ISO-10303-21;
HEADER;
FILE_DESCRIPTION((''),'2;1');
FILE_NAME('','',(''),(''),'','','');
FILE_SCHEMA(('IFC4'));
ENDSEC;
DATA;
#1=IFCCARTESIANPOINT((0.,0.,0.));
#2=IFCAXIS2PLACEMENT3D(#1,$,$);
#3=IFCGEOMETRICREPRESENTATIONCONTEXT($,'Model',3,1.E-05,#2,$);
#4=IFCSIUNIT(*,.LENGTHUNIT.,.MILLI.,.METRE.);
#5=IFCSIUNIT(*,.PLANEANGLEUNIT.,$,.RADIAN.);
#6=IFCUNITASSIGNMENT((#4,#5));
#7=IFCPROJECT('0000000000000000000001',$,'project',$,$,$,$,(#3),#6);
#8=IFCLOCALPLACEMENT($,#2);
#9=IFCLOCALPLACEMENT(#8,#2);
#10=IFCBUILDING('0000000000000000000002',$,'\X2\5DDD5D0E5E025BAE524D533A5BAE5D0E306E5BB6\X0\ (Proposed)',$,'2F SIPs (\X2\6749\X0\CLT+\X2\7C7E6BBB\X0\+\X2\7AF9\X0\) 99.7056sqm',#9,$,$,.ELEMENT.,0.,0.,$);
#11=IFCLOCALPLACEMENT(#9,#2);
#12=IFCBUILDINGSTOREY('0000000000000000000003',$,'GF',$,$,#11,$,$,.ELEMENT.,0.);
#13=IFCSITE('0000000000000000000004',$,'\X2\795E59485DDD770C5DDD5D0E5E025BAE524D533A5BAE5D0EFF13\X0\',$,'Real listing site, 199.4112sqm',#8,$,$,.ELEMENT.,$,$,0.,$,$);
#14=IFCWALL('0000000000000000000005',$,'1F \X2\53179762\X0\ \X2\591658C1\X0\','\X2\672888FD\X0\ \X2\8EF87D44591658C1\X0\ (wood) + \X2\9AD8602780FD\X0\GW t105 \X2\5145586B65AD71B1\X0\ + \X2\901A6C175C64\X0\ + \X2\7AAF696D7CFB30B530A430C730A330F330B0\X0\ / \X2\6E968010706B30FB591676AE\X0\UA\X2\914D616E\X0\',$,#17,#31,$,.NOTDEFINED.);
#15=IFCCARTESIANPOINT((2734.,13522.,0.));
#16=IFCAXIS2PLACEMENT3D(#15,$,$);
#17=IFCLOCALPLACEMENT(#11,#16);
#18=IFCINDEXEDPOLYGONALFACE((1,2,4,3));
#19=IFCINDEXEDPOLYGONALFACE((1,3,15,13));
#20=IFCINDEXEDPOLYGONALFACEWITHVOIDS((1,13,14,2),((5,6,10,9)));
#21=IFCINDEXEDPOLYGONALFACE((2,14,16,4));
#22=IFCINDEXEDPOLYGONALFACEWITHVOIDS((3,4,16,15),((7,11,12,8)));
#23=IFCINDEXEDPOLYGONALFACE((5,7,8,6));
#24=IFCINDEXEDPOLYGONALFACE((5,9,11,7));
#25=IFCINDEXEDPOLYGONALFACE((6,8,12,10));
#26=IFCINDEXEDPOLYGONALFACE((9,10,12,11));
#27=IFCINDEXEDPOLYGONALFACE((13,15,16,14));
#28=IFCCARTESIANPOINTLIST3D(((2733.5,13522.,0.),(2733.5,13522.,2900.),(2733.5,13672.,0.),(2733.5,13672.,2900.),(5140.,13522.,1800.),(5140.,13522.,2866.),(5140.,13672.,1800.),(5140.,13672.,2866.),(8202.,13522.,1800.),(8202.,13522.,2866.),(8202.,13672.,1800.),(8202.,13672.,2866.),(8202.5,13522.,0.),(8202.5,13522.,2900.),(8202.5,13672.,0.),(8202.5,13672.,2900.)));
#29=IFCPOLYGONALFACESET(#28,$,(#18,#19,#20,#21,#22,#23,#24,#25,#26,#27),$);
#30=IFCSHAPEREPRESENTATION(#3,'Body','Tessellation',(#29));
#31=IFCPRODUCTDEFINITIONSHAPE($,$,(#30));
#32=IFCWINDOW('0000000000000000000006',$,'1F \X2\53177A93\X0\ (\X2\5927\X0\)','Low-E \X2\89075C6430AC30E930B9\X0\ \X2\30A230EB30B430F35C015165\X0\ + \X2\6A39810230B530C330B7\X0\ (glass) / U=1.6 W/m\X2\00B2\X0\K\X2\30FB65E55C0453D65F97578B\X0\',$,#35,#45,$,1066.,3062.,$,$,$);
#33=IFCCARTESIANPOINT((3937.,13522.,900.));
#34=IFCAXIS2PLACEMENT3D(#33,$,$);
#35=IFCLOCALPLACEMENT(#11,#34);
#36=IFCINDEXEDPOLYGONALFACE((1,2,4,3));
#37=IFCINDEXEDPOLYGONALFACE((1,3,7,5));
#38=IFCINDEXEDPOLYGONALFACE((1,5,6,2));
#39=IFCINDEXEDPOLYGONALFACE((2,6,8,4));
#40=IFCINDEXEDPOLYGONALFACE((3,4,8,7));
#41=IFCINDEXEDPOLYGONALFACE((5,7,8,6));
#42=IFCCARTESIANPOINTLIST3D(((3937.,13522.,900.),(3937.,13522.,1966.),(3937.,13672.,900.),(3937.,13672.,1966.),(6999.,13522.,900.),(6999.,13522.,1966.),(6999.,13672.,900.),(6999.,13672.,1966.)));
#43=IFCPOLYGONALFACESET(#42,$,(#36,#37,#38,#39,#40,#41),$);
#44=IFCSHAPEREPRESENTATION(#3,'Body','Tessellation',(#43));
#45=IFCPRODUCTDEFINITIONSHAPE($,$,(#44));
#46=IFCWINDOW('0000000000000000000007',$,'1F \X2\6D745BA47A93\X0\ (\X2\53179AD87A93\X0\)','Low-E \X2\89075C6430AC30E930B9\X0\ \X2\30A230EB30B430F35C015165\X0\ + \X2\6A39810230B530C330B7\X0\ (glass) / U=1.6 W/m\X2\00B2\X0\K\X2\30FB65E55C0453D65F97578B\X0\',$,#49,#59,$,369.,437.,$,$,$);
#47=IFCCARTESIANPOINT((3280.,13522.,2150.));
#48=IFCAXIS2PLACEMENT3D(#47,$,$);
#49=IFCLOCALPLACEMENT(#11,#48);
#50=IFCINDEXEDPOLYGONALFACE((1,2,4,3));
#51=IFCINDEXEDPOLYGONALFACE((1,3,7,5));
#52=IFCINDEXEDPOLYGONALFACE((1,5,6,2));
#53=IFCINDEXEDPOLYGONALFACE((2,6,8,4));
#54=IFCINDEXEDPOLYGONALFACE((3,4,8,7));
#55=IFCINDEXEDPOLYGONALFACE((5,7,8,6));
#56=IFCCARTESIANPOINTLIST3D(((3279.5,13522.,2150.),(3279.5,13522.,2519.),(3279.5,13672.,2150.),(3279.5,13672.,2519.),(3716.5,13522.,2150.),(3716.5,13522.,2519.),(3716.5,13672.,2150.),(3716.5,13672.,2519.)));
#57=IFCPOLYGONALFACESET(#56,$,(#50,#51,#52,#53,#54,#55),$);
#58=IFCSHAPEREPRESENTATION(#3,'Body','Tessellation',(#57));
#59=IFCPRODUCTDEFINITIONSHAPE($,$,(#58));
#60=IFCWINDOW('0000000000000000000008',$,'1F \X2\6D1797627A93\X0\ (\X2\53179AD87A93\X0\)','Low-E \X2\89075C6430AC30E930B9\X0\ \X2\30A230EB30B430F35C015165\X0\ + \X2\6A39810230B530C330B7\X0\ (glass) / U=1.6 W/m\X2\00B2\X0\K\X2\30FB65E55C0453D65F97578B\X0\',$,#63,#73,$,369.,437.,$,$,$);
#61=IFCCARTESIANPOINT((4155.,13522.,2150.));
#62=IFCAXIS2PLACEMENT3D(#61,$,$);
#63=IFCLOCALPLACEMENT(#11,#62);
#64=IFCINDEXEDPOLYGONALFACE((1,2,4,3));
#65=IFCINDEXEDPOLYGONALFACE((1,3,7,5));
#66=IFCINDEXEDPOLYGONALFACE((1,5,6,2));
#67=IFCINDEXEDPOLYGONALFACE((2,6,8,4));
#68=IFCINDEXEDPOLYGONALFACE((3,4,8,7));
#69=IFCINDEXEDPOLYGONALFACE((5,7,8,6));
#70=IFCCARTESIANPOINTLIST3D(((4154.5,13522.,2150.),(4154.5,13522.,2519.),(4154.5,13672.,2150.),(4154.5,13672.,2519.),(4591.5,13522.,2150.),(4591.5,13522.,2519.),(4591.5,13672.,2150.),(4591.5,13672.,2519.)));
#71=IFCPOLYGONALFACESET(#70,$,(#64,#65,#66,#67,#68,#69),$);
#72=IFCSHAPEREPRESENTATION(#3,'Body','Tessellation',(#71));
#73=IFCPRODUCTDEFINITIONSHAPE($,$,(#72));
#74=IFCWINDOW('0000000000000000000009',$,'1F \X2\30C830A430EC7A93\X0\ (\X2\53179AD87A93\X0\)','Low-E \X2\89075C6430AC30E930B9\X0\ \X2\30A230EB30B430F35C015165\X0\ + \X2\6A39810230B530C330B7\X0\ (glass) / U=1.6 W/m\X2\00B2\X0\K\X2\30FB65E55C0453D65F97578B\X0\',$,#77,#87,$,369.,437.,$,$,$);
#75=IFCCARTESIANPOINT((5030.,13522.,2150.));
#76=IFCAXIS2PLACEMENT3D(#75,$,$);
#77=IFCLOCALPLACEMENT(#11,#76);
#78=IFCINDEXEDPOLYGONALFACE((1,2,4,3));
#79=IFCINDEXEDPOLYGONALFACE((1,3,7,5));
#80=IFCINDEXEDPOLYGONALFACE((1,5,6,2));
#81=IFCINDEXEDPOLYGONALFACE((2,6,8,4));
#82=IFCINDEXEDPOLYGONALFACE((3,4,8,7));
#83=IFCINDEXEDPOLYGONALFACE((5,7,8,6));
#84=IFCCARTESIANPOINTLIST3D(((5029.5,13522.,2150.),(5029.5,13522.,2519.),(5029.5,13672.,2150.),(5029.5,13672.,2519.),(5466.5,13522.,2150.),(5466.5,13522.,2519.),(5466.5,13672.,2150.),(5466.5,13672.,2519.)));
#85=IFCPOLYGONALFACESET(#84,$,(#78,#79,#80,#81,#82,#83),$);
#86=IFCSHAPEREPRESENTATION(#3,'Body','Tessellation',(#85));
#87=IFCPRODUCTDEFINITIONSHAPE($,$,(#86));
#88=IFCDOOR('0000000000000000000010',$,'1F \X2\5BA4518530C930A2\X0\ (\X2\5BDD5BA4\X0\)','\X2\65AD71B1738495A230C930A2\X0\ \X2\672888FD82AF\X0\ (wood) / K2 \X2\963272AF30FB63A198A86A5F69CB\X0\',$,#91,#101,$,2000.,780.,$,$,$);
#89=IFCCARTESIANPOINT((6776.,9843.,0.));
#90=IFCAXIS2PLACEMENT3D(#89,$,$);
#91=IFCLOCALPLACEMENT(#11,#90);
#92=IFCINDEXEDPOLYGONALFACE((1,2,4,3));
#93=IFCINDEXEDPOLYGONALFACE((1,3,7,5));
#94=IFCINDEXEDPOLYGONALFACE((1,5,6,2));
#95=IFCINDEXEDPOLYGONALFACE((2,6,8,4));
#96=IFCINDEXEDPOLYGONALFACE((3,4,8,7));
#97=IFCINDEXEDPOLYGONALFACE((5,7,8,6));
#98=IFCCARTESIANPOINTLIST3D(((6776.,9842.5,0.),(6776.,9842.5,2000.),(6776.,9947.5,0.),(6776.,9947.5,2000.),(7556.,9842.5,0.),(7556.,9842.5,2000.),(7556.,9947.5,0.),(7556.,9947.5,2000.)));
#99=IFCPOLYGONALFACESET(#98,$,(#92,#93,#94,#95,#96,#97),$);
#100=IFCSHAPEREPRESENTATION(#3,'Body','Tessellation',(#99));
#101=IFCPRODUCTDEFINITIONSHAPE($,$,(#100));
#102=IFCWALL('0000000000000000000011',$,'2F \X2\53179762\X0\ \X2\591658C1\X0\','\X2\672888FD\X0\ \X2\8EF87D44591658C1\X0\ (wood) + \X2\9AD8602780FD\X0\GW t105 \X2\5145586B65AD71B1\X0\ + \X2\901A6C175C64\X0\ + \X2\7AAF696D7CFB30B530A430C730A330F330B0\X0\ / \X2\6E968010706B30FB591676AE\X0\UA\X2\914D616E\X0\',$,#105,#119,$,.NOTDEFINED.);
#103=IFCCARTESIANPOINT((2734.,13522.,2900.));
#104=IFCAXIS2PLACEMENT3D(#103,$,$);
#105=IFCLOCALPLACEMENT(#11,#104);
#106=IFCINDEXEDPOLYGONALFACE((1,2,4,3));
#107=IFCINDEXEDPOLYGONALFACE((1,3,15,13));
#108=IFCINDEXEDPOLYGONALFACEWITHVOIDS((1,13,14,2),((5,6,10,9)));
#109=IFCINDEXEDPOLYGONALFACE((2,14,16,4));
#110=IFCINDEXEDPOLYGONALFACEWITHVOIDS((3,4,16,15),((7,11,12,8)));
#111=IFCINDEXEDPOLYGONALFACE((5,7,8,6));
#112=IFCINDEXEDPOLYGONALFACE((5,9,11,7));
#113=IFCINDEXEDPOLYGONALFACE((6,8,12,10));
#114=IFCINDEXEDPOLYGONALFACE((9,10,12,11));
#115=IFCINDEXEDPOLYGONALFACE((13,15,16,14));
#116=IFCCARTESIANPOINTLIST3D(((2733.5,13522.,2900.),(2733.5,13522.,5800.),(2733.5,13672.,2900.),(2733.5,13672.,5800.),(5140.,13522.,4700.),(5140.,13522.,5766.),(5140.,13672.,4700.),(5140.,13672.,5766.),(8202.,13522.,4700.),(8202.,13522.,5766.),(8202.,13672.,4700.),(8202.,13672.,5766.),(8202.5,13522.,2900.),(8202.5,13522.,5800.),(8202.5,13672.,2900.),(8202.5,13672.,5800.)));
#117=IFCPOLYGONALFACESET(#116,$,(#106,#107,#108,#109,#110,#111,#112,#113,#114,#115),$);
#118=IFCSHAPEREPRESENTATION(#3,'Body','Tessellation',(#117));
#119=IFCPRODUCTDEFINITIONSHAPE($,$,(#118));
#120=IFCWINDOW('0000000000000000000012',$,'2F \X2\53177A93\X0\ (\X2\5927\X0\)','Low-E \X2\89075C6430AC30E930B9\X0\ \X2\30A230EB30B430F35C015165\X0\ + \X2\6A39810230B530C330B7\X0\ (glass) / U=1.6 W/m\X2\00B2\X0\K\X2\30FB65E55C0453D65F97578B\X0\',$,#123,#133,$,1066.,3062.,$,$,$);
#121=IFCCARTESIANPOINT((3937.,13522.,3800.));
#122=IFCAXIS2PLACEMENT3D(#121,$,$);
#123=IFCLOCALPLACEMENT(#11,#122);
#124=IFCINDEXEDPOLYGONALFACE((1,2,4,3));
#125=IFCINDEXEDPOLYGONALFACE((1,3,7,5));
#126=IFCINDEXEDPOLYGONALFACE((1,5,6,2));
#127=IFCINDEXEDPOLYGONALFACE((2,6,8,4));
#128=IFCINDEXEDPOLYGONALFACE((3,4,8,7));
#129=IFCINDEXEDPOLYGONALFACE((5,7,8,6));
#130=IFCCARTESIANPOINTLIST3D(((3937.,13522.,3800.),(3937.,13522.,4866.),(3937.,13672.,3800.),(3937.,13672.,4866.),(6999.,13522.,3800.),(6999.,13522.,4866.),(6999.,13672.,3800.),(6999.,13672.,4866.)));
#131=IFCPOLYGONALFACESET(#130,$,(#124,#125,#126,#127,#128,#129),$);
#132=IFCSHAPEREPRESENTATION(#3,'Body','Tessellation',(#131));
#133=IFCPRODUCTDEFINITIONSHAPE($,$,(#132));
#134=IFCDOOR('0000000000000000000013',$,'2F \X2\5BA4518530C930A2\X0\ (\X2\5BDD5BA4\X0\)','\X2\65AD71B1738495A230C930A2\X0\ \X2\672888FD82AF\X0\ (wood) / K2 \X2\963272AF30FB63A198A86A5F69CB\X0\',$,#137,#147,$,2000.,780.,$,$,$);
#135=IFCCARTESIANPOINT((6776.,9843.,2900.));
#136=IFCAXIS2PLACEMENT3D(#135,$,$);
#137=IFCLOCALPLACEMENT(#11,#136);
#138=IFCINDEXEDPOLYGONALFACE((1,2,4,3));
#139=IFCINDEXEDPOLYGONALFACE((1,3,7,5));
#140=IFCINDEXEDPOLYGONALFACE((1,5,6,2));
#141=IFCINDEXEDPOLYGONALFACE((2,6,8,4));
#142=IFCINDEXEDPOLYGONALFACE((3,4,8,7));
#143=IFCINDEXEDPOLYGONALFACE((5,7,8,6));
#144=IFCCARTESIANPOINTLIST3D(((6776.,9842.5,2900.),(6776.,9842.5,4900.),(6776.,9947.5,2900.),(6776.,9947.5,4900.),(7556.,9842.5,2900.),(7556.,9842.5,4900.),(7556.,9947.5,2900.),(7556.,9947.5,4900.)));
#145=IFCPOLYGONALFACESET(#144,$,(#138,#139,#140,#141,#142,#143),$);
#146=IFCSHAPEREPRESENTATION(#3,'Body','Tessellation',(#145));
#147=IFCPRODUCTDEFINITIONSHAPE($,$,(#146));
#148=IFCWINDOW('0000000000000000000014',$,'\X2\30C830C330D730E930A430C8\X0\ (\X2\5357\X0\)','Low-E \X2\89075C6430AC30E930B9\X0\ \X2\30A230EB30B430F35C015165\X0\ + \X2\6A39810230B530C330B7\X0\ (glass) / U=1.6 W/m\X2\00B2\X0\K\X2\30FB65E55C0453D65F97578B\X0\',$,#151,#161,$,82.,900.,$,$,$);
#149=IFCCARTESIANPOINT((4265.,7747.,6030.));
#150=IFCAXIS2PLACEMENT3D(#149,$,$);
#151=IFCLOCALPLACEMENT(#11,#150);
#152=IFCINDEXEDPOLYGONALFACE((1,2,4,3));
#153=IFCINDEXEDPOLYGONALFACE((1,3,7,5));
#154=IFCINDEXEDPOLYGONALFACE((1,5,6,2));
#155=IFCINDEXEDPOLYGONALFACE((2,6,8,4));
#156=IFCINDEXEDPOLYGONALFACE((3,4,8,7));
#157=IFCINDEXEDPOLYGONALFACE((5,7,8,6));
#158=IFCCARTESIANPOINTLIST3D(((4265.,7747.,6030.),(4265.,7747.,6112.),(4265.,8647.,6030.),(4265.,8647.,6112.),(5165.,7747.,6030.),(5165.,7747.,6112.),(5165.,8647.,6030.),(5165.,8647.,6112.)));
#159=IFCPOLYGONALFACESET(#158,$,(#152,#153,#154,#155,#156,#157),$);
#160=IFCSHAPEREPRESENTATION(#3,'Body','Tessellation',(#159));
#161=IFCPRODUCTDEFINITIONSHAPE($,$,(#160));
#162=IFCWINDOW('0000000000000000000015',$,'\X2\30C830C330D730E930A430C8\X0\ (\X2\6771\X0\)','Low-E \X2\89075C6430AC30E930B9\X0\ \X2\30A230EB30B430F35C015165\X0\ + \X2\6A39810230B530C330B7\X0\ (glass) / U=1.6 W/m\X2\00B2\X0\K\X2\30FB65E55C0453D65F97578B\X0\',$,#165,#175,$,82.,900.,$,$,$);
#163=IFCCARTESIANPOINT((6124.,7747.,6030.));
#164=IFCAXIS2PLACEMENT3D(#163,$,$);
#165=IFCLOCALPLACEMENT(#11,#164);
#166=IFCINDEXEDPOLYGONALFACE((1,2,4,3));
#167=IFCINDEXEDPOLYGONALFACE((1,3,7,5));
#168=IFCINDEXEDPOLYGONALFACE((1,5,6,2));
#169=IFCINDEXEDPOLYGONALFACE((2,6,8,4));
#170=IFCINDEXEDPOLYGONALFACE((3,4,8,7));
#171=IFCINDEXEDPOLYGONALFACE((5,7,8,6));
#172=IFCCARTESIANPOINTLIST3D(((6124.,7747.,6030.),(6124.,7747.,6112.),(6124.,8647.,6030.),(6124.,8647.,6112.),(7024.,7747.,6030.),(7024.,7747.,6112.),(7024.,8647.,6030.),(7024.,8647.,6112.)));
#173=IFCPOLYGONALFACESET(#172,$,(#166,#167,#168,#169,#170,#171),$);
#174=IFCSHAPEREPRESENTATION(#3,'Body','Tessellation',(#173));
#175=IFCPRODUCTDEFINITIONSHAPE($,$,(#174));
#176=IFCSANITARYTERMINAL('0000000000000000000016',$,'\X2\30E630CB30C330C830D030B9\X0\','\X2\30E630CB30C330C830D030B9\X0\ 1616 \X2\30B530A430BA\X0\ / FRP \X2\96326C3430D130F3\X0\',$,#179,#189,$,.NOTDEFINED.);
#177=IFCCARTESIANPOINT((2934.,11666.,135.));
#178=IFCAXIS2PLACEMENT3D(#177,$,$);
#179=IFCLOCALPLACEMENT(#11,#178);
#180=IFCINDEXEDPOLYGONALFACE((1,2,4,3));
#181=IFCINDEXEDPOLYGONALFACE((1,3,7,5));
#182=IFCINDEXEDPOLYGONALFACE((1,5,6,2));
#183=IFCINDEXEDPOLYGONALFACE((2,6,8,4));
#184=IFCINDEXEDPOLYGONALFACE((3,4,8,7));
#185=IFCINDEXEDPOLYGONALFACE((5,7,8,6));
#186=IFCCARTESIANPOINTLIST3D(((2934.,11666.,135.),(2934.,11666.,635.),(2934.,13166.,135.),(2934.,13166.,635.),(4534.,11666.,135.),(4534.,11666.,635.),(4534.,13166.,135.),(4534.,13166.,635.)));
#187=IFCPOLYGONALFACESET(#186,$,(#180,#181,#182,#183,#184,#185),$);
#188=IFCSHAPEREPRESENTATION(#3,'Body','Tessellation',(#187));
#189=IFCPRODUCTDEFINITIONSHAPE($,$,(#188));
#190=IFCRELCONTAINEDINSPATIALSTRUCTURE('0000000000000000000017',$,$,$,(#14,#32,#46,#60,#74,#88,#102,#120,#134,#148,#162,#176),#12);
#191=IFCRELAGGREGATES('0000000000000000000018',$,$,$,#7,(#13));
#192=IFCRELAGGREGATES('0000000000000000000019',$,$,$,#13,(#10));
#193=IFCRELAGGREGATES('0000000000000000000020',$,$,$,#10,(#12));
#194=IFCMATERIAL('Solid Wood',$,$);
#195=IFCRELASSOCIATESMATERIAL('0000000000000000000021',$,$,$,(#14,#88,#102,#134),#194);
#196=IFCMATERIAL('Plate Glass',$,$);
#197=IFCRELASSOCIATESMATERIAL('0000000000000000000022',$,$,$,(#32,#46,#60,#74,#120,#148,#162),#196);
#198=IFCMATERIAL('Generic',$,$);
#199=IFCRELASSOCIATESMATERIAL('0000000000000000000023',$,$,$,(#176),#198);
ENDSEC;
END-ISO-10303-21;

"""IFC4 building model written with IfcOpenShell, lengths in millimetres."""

from ifc_helpers import new_model, si_unit, frame, frame_2d, origin, place, context, project, spatial, rectangle, extrude, material, element, fill, save


model = new_model("IFC4")

# Units and contexts
model_context = context("Model", 3, precision=1e-05, world=origin())
ifc_project = project(units=[si_unit("LENGTHUNIT", "METRE", prefix="MILLI"), si_unit("PLANEANGLEUNIT", "RADIAN")], contexts=[model_context])

# Site, building, storey
site_placement = place(None, origin())
site = spatial("IfcSite", under=ifc_project, at=site_placement, Name="神奈川県川崎市宮前区宮崎３", ObjectType="Real listing site, 199.4112sqm", CompositionType="ELEMENT", RefElevation=0.0)
building_placement = place(site_placement, origin())
building = spatial("IfcBuilding", under=site, at=building_placement, Name="川崎市宮前区宮崎の家 (Proposed)", ObjectType="2F SIPs (杉CLT+籾殻+竹) 99.7056sqm", CompositionType="ELEMENT", ElevationOfRefHeight=0.0, ElevationOfTerrain=0.0)
storey_placement = place(building_placement, origin())
storey = spatial("IfcBuildingStorey", under=building, at=storey_placement, Name="GF", CompositionType="ELEMENT", Elevation=0.0)

# Wall, openings, windows
ifc_material_1 = material(Name="Solid Wood")
wall_1_placement = place(storey_placement, frame((2734.0, 13522.0, 0.0)))
wall_1 = element("IfcWall", 1, at=wall_1_placement, inside=storey, material=ifc_material_1, Name="1F 北面 外壁", Description="木製 軸組外壁 (wood) + 高性能GW t105 充填断熱 + 通気層 + 窯業系サイディング / 準耐火・外皮UA配慮", PredefinedType="NOTDEFINED", context=model_context, shape_type="SweptSolid", body=[
    extrude(rectangle(XDim=5469.0, YDim=150.0, at=frame_2d((2734.0, 75.0))), frame((2734.0, 13522.0, 0.0)), (0.0, 0.0, 1.0), 2900.0),
])
opening_1_placement = place(storey_placement, frame((3937.0, 13522.0, 900.0)))
opening_1 = element("IfcOpeningElement", 2, at=opening_1_placement, cuts=wall_1, PredefinedType="NOTDEFINED", context=model_context, shape_type="SweptSolid", body=[
    extrude(rectangle(XDim=3062.0, YDim=150.0, at=frame_2d((1531.0, 75.0))), frame((3937.0, 13522.0, 900.0)), (0.0, 0.0, 1.0), 1066.0),
])
opening_2_placement = place(storey_placement, frame((3280.0, 13522.0, 2150.0)))
opening_2 = element("IfcOpeningElement", 3, at=opening_2_placement, cuts=wall_1, PredefinedType="NOTDEFINED", context=model_context, shape_type="SweptSolid", body=[
    extrude(rectangle(XDim=437.0, YDim=150.0, at=frame_2d((218.0, 75.0))), frame((3280.0, 13522.0, 2150.0)), (0.0, 0.0, 1.0), 369.0),
])
opening_3_placement = place(storey_placement, frame((4155.0, 13522.0, 2150.0)))
opening_3 = element("IfcOpeningElement", 4, at=opening_3_placement, cuts=wall_1, PredefinedType="NOTDEFINED", context=model_context, shape_type="SweptSolid", body=[
    extrude(rectangle(XDim=437.0, YDim=150.0, at=frame_2d((218.0, 75.0))), frame((4155.0, 13522.0, 2150.0)), (0.0, 0.0, 1.0), 369.0),
])
opening_4_placement = place(storey_placement, frame((5030.0, 13522.0, 2150.0)))
opening_4 = element("IfcOpeningElement", 5, at=opening_4_placement, cuts=wall_1, PredefinedType="NOTDEFINED", context=model_context, shape_type="SweptSolid", body=[
    extrude(rectangle(XDim=437.0, YDim=150.0, at=frame_2d((218.0, 75.0))), frame((5030.0, 13522.0, 2150.0)), (0.0, 0.0, 1.0), 369.0),
])
ifc_material_2 = material(Name="Plate Glass")
window_1_placement = place(storey_placement, frame((3937.0, 13522.0, 900.0)))
window_1 = element("IfcWindow", 6, at=window_1_placement, inside=storey, material=ifc_material_2, Name="1F 北窓 (大)", Description="Low-E 複層ガラス アルゴン封入 + 樹脂サッシ (glass) / U=1.6 W/m²K・日射取得型", OverallHeight=1066.0, OverallWidth=3062.0, context=model_context, shape_type="SweptSolid", body=[
    extrude(rectangle(XDim=3062.0, YDim=150.0, at=frame_2d((1531.0, 75.0))), frame((3937.0, 13522.0, 900.0)), (0.0, 0.0, 1.0), 1066.0),
])
fill(opening_1, window_1)
window_2_placement = place(storey_placement, frame((3280.0, 13522.0, 2150.0)))
window_2 = element("IfcWindow", 7, at=window_2_placement, inside=storey, material=ifc_material_2, Name="1F 浴室窓 (北高窓)", Description="Low-E 複層ガラス アルゴン封入 + 樹脂サッシ (glass) / U=1.6 W/m²K・日射取得型", OverallHeight=369.0, OverallWidth=437.0, context=model_context, shape_type="SweptSolid", body=[
    extrude(rectangle(XDim=437.0, YDim=150.0, at=frame_2d((218.0, 75.0))), frame((3280.0, 13522.0, 2150.0)), (0.0, 0.0, 1.0), 369.0),
])
fill(opening_2, window_2)
window_3_placement = place(storey_placement, frame((4155.0, 13522.0, 2150.0)))
window_3 = element("IfcWindow", 8, at=window_3_placement, inside=storey, material=ifc_material_2, Name="1F 洗面窓 (北高窓)", Description="Low-E 複層ガラス アルゴン封入 + 樹脂サッシ (glass) / U=1.6 W/m²K・日射取得型", OverallHeight=369.0, OverallWidth=437.0, context=model_context, shape_type="SweptSolid", body=[
    extrude(rectangle(XDim=437.0, YDim=150.0, at=frame_2d((218.0, 75.0))), frame((4155.0, 13522.0, 2150.0)), (0.0, 0.0, 1.0), 369.0),
])
fill(opening_3, window_3)
window_4_placement = place(storey_placement, frame((5030.0, 13522.0, 2150.0)))
window_4 = element("IfcWindow", 9, at=window_4_placement, inside=storey, material=ifc_material_2, Name="1F トイレ窓 (北高窓)", Description="Low-E 複層ガラス アルゴン封入 + 樹脂サッシ (glass) / U=1.6 W/m²K・日射取得型", OverallHeight=369.0, OverallWidth=437.0, context=model_context, shape_type="SweptSolid", body=[
    extrude(rectangle(XDim=437.0, YDim=150.0, at=frame_2d((218.0, 75.0))), frame((5030.0, 13522.0, 2150.0)), (0.0, 0.0, 1.0), 369.0),
])
fill(opening_4, window_4)

# Door
door_1_placement = place(storey_placement, frame((6776.0, 9843.0, 0.0)))
element("IfcDoor", 10, at=door_1_placement, inside=storey, material=ifc_material_1, Name="1F 室内ドア (寝室)", Description="断熱玄関ドア 木製芯 (wood) / K2 防犯・採風機構", OverallHeight=2000.0, OverallWidth=780.0, context=model_context, shape_type="SweptSolid", body=[
    extrude(rectangle(XDim=780.0, YDim=105.0, at=frame_2d((390.0, 52.0))), frame((6776.0, 9843.0, 0.0)), (0.0, 0.0, 1.0), 2000.0),
])

# Wall, opening, window
wall_2_placement = place(storey_placement, frame((2734.0, 13522.0, 2900.0)))
wall_2 = element("IfcWall", 11, at=wall_2_placement, inside=storey, material=ifc_material_1, Name="2F 北面 外壁", Description="木製 軸組外壁 (wood) + 高性能GW t105 充填断熱 + 通気層 + 窯業系サイディング / 準耐火・外皮UA配慮", PredefinedType="NOTDEFINED", context=model_context, shape_type="SweptSolid", body=[
    extrude(rectangle(XDim=5469.0, YDim=150.0, at=frame_2d((2734.0, 75.0))), frame((2734.0, 13522.0, 2900.0)), (0.0, 0.0, 1.0), 2900.0),
])
opening_5_placement = place(storey_placement, frame((3937.0, 13522.0, 3800.0)))
opening_5 = element("IfcOpeningElement", 12, at=opening_5_placement, cuts=wall_2, PredefinedType="NOTDEFINED", context=model_context, shape_type="SweptSolid", body=[
    extrude(rectangle(XDim=3062.0, YDim=150.0, at=frame_2d((1531.0, 75.0))), frame((3937.0, 13522.0, 3800.0)), (0.0, 0.0, 1.0), 1066.0),
])
window_5_placement = place(storey_placement, frame((3937.0, 13522.0, 3800.0)))
window_5 = element("IfcWindow", 13, at=window_5_placement, inside=storey, material=ifc_material_2, Name="2F 北窓 (大)", Description="Low-E 複層ガラス アルゴン封入 + 樹脂サッシ (glass) / U=1.6 W/m²K・日射取得型", OverallHeight=1066.0, OverallWidth=3062.0, context=model_context, shape_type="SweptSolid", body=[
    extrude(rectangle(XDim=3062.0, YDim=150.0, at=frame_2d((1531.0, 75.0))), frame((3937.0, 13522.0, 3800.0)), (0.0, 0.0, 1.0), 1066.0),
])
fill(opening_5, window_5)

# Door
door_2_placement = place(storey_placement, frame((6776.0, 9843.0, 2900.0)))
element("IfcDoor", 14, at=door_2_placement, inside=storey, material=ifc_material_1, Name="2F 室内ドア (寝室)", Description="断熱玄関ドア 木製芯 (wood) / K2 防犯・採風機構", OverallHeight=2000.0, OverallWidth=780.0, context=model_context, shape_type="SweptSolid", body=[
    extrude(rectangle(XDim=780.0, YDim=105.0, at=frame_2d((390.0, 52.0))), frame((6776.0, 9843.0, 2900.0)), (0.0, 0.0, 1.0), 2000.0),
])

# Windows
window_6_placement = place(storey_placement, frame((4265.0, 7747.0, 6030.0)))
element("IfcWindow", 15, at=window_6_placement, inside=storey, material=ifc_material_2, Name="トップライト (南)", Description="Low-E 複層ガラス アルゴン封入 + 樹脂サッシ (glass) / U=1.6 W/m²K・日射取得型", OverallHeight=82.0, OverallWidth=900.0, context=model_context, shape_type="SweptSolid", body=[
    extrude(rectangle(XDim=900.0, YDim=900.0, at=frame_2d((450.0, 450.0))), frame((4265.0, 7747.0, 6030.0)), (0.0, 0.0, 1.0), 82.0),
])
window_7_placement = place(storey_placement, frame((6124.0, 7747.0, 6030.0)))
element("IfcWindow", 16, at=window_7_placement, inside=storey, material=ifc_material_2, Name="トップライト (東)", Description="Low-E 複層ガラス アルゴン封入 + 樹脂サッシ (glass) / U=1.6 W/m²K・日射取得型", OverallHeight=82.0, OverallWidth=900.0, context=model_context, shape_type="SweptSolid", body=[
    extrude(rectangle(XDim=900.0, YDim=900.0, at=frame_2d((450.0, 450.0))), frame((6124.0, 7747.0, 6030.0)), (0.0, 0.0, 1.0), 82.0),
])

# Sanitary terminal
ifc_material_3 = material(Name="Generic")
sanitary_terminal_1_placement = place(storey_placement, frame((2934.0, 11666.0, 135.0)))
element("IfcSanitaryTerminal", 17, at=sanitary_terminal_1_placement, inside=storey, material=ifc_material_3, Name="ユニットバス", Description="ユニットバス 1616 サイズ / FRP 防水パン", PredefinedType="NOTDEFINED", context=model_context, shape_type="SweptSolid", body=[
    extrude(rectangle(XDim=1600.0, YDim=1500.0, at=frame_2d((800.0, 750.0))), frame((2934.0, 11666.0, 135.0)), (0.0, 0.0, 1.0), 500.0),
])

save(model, "model.ifc")
